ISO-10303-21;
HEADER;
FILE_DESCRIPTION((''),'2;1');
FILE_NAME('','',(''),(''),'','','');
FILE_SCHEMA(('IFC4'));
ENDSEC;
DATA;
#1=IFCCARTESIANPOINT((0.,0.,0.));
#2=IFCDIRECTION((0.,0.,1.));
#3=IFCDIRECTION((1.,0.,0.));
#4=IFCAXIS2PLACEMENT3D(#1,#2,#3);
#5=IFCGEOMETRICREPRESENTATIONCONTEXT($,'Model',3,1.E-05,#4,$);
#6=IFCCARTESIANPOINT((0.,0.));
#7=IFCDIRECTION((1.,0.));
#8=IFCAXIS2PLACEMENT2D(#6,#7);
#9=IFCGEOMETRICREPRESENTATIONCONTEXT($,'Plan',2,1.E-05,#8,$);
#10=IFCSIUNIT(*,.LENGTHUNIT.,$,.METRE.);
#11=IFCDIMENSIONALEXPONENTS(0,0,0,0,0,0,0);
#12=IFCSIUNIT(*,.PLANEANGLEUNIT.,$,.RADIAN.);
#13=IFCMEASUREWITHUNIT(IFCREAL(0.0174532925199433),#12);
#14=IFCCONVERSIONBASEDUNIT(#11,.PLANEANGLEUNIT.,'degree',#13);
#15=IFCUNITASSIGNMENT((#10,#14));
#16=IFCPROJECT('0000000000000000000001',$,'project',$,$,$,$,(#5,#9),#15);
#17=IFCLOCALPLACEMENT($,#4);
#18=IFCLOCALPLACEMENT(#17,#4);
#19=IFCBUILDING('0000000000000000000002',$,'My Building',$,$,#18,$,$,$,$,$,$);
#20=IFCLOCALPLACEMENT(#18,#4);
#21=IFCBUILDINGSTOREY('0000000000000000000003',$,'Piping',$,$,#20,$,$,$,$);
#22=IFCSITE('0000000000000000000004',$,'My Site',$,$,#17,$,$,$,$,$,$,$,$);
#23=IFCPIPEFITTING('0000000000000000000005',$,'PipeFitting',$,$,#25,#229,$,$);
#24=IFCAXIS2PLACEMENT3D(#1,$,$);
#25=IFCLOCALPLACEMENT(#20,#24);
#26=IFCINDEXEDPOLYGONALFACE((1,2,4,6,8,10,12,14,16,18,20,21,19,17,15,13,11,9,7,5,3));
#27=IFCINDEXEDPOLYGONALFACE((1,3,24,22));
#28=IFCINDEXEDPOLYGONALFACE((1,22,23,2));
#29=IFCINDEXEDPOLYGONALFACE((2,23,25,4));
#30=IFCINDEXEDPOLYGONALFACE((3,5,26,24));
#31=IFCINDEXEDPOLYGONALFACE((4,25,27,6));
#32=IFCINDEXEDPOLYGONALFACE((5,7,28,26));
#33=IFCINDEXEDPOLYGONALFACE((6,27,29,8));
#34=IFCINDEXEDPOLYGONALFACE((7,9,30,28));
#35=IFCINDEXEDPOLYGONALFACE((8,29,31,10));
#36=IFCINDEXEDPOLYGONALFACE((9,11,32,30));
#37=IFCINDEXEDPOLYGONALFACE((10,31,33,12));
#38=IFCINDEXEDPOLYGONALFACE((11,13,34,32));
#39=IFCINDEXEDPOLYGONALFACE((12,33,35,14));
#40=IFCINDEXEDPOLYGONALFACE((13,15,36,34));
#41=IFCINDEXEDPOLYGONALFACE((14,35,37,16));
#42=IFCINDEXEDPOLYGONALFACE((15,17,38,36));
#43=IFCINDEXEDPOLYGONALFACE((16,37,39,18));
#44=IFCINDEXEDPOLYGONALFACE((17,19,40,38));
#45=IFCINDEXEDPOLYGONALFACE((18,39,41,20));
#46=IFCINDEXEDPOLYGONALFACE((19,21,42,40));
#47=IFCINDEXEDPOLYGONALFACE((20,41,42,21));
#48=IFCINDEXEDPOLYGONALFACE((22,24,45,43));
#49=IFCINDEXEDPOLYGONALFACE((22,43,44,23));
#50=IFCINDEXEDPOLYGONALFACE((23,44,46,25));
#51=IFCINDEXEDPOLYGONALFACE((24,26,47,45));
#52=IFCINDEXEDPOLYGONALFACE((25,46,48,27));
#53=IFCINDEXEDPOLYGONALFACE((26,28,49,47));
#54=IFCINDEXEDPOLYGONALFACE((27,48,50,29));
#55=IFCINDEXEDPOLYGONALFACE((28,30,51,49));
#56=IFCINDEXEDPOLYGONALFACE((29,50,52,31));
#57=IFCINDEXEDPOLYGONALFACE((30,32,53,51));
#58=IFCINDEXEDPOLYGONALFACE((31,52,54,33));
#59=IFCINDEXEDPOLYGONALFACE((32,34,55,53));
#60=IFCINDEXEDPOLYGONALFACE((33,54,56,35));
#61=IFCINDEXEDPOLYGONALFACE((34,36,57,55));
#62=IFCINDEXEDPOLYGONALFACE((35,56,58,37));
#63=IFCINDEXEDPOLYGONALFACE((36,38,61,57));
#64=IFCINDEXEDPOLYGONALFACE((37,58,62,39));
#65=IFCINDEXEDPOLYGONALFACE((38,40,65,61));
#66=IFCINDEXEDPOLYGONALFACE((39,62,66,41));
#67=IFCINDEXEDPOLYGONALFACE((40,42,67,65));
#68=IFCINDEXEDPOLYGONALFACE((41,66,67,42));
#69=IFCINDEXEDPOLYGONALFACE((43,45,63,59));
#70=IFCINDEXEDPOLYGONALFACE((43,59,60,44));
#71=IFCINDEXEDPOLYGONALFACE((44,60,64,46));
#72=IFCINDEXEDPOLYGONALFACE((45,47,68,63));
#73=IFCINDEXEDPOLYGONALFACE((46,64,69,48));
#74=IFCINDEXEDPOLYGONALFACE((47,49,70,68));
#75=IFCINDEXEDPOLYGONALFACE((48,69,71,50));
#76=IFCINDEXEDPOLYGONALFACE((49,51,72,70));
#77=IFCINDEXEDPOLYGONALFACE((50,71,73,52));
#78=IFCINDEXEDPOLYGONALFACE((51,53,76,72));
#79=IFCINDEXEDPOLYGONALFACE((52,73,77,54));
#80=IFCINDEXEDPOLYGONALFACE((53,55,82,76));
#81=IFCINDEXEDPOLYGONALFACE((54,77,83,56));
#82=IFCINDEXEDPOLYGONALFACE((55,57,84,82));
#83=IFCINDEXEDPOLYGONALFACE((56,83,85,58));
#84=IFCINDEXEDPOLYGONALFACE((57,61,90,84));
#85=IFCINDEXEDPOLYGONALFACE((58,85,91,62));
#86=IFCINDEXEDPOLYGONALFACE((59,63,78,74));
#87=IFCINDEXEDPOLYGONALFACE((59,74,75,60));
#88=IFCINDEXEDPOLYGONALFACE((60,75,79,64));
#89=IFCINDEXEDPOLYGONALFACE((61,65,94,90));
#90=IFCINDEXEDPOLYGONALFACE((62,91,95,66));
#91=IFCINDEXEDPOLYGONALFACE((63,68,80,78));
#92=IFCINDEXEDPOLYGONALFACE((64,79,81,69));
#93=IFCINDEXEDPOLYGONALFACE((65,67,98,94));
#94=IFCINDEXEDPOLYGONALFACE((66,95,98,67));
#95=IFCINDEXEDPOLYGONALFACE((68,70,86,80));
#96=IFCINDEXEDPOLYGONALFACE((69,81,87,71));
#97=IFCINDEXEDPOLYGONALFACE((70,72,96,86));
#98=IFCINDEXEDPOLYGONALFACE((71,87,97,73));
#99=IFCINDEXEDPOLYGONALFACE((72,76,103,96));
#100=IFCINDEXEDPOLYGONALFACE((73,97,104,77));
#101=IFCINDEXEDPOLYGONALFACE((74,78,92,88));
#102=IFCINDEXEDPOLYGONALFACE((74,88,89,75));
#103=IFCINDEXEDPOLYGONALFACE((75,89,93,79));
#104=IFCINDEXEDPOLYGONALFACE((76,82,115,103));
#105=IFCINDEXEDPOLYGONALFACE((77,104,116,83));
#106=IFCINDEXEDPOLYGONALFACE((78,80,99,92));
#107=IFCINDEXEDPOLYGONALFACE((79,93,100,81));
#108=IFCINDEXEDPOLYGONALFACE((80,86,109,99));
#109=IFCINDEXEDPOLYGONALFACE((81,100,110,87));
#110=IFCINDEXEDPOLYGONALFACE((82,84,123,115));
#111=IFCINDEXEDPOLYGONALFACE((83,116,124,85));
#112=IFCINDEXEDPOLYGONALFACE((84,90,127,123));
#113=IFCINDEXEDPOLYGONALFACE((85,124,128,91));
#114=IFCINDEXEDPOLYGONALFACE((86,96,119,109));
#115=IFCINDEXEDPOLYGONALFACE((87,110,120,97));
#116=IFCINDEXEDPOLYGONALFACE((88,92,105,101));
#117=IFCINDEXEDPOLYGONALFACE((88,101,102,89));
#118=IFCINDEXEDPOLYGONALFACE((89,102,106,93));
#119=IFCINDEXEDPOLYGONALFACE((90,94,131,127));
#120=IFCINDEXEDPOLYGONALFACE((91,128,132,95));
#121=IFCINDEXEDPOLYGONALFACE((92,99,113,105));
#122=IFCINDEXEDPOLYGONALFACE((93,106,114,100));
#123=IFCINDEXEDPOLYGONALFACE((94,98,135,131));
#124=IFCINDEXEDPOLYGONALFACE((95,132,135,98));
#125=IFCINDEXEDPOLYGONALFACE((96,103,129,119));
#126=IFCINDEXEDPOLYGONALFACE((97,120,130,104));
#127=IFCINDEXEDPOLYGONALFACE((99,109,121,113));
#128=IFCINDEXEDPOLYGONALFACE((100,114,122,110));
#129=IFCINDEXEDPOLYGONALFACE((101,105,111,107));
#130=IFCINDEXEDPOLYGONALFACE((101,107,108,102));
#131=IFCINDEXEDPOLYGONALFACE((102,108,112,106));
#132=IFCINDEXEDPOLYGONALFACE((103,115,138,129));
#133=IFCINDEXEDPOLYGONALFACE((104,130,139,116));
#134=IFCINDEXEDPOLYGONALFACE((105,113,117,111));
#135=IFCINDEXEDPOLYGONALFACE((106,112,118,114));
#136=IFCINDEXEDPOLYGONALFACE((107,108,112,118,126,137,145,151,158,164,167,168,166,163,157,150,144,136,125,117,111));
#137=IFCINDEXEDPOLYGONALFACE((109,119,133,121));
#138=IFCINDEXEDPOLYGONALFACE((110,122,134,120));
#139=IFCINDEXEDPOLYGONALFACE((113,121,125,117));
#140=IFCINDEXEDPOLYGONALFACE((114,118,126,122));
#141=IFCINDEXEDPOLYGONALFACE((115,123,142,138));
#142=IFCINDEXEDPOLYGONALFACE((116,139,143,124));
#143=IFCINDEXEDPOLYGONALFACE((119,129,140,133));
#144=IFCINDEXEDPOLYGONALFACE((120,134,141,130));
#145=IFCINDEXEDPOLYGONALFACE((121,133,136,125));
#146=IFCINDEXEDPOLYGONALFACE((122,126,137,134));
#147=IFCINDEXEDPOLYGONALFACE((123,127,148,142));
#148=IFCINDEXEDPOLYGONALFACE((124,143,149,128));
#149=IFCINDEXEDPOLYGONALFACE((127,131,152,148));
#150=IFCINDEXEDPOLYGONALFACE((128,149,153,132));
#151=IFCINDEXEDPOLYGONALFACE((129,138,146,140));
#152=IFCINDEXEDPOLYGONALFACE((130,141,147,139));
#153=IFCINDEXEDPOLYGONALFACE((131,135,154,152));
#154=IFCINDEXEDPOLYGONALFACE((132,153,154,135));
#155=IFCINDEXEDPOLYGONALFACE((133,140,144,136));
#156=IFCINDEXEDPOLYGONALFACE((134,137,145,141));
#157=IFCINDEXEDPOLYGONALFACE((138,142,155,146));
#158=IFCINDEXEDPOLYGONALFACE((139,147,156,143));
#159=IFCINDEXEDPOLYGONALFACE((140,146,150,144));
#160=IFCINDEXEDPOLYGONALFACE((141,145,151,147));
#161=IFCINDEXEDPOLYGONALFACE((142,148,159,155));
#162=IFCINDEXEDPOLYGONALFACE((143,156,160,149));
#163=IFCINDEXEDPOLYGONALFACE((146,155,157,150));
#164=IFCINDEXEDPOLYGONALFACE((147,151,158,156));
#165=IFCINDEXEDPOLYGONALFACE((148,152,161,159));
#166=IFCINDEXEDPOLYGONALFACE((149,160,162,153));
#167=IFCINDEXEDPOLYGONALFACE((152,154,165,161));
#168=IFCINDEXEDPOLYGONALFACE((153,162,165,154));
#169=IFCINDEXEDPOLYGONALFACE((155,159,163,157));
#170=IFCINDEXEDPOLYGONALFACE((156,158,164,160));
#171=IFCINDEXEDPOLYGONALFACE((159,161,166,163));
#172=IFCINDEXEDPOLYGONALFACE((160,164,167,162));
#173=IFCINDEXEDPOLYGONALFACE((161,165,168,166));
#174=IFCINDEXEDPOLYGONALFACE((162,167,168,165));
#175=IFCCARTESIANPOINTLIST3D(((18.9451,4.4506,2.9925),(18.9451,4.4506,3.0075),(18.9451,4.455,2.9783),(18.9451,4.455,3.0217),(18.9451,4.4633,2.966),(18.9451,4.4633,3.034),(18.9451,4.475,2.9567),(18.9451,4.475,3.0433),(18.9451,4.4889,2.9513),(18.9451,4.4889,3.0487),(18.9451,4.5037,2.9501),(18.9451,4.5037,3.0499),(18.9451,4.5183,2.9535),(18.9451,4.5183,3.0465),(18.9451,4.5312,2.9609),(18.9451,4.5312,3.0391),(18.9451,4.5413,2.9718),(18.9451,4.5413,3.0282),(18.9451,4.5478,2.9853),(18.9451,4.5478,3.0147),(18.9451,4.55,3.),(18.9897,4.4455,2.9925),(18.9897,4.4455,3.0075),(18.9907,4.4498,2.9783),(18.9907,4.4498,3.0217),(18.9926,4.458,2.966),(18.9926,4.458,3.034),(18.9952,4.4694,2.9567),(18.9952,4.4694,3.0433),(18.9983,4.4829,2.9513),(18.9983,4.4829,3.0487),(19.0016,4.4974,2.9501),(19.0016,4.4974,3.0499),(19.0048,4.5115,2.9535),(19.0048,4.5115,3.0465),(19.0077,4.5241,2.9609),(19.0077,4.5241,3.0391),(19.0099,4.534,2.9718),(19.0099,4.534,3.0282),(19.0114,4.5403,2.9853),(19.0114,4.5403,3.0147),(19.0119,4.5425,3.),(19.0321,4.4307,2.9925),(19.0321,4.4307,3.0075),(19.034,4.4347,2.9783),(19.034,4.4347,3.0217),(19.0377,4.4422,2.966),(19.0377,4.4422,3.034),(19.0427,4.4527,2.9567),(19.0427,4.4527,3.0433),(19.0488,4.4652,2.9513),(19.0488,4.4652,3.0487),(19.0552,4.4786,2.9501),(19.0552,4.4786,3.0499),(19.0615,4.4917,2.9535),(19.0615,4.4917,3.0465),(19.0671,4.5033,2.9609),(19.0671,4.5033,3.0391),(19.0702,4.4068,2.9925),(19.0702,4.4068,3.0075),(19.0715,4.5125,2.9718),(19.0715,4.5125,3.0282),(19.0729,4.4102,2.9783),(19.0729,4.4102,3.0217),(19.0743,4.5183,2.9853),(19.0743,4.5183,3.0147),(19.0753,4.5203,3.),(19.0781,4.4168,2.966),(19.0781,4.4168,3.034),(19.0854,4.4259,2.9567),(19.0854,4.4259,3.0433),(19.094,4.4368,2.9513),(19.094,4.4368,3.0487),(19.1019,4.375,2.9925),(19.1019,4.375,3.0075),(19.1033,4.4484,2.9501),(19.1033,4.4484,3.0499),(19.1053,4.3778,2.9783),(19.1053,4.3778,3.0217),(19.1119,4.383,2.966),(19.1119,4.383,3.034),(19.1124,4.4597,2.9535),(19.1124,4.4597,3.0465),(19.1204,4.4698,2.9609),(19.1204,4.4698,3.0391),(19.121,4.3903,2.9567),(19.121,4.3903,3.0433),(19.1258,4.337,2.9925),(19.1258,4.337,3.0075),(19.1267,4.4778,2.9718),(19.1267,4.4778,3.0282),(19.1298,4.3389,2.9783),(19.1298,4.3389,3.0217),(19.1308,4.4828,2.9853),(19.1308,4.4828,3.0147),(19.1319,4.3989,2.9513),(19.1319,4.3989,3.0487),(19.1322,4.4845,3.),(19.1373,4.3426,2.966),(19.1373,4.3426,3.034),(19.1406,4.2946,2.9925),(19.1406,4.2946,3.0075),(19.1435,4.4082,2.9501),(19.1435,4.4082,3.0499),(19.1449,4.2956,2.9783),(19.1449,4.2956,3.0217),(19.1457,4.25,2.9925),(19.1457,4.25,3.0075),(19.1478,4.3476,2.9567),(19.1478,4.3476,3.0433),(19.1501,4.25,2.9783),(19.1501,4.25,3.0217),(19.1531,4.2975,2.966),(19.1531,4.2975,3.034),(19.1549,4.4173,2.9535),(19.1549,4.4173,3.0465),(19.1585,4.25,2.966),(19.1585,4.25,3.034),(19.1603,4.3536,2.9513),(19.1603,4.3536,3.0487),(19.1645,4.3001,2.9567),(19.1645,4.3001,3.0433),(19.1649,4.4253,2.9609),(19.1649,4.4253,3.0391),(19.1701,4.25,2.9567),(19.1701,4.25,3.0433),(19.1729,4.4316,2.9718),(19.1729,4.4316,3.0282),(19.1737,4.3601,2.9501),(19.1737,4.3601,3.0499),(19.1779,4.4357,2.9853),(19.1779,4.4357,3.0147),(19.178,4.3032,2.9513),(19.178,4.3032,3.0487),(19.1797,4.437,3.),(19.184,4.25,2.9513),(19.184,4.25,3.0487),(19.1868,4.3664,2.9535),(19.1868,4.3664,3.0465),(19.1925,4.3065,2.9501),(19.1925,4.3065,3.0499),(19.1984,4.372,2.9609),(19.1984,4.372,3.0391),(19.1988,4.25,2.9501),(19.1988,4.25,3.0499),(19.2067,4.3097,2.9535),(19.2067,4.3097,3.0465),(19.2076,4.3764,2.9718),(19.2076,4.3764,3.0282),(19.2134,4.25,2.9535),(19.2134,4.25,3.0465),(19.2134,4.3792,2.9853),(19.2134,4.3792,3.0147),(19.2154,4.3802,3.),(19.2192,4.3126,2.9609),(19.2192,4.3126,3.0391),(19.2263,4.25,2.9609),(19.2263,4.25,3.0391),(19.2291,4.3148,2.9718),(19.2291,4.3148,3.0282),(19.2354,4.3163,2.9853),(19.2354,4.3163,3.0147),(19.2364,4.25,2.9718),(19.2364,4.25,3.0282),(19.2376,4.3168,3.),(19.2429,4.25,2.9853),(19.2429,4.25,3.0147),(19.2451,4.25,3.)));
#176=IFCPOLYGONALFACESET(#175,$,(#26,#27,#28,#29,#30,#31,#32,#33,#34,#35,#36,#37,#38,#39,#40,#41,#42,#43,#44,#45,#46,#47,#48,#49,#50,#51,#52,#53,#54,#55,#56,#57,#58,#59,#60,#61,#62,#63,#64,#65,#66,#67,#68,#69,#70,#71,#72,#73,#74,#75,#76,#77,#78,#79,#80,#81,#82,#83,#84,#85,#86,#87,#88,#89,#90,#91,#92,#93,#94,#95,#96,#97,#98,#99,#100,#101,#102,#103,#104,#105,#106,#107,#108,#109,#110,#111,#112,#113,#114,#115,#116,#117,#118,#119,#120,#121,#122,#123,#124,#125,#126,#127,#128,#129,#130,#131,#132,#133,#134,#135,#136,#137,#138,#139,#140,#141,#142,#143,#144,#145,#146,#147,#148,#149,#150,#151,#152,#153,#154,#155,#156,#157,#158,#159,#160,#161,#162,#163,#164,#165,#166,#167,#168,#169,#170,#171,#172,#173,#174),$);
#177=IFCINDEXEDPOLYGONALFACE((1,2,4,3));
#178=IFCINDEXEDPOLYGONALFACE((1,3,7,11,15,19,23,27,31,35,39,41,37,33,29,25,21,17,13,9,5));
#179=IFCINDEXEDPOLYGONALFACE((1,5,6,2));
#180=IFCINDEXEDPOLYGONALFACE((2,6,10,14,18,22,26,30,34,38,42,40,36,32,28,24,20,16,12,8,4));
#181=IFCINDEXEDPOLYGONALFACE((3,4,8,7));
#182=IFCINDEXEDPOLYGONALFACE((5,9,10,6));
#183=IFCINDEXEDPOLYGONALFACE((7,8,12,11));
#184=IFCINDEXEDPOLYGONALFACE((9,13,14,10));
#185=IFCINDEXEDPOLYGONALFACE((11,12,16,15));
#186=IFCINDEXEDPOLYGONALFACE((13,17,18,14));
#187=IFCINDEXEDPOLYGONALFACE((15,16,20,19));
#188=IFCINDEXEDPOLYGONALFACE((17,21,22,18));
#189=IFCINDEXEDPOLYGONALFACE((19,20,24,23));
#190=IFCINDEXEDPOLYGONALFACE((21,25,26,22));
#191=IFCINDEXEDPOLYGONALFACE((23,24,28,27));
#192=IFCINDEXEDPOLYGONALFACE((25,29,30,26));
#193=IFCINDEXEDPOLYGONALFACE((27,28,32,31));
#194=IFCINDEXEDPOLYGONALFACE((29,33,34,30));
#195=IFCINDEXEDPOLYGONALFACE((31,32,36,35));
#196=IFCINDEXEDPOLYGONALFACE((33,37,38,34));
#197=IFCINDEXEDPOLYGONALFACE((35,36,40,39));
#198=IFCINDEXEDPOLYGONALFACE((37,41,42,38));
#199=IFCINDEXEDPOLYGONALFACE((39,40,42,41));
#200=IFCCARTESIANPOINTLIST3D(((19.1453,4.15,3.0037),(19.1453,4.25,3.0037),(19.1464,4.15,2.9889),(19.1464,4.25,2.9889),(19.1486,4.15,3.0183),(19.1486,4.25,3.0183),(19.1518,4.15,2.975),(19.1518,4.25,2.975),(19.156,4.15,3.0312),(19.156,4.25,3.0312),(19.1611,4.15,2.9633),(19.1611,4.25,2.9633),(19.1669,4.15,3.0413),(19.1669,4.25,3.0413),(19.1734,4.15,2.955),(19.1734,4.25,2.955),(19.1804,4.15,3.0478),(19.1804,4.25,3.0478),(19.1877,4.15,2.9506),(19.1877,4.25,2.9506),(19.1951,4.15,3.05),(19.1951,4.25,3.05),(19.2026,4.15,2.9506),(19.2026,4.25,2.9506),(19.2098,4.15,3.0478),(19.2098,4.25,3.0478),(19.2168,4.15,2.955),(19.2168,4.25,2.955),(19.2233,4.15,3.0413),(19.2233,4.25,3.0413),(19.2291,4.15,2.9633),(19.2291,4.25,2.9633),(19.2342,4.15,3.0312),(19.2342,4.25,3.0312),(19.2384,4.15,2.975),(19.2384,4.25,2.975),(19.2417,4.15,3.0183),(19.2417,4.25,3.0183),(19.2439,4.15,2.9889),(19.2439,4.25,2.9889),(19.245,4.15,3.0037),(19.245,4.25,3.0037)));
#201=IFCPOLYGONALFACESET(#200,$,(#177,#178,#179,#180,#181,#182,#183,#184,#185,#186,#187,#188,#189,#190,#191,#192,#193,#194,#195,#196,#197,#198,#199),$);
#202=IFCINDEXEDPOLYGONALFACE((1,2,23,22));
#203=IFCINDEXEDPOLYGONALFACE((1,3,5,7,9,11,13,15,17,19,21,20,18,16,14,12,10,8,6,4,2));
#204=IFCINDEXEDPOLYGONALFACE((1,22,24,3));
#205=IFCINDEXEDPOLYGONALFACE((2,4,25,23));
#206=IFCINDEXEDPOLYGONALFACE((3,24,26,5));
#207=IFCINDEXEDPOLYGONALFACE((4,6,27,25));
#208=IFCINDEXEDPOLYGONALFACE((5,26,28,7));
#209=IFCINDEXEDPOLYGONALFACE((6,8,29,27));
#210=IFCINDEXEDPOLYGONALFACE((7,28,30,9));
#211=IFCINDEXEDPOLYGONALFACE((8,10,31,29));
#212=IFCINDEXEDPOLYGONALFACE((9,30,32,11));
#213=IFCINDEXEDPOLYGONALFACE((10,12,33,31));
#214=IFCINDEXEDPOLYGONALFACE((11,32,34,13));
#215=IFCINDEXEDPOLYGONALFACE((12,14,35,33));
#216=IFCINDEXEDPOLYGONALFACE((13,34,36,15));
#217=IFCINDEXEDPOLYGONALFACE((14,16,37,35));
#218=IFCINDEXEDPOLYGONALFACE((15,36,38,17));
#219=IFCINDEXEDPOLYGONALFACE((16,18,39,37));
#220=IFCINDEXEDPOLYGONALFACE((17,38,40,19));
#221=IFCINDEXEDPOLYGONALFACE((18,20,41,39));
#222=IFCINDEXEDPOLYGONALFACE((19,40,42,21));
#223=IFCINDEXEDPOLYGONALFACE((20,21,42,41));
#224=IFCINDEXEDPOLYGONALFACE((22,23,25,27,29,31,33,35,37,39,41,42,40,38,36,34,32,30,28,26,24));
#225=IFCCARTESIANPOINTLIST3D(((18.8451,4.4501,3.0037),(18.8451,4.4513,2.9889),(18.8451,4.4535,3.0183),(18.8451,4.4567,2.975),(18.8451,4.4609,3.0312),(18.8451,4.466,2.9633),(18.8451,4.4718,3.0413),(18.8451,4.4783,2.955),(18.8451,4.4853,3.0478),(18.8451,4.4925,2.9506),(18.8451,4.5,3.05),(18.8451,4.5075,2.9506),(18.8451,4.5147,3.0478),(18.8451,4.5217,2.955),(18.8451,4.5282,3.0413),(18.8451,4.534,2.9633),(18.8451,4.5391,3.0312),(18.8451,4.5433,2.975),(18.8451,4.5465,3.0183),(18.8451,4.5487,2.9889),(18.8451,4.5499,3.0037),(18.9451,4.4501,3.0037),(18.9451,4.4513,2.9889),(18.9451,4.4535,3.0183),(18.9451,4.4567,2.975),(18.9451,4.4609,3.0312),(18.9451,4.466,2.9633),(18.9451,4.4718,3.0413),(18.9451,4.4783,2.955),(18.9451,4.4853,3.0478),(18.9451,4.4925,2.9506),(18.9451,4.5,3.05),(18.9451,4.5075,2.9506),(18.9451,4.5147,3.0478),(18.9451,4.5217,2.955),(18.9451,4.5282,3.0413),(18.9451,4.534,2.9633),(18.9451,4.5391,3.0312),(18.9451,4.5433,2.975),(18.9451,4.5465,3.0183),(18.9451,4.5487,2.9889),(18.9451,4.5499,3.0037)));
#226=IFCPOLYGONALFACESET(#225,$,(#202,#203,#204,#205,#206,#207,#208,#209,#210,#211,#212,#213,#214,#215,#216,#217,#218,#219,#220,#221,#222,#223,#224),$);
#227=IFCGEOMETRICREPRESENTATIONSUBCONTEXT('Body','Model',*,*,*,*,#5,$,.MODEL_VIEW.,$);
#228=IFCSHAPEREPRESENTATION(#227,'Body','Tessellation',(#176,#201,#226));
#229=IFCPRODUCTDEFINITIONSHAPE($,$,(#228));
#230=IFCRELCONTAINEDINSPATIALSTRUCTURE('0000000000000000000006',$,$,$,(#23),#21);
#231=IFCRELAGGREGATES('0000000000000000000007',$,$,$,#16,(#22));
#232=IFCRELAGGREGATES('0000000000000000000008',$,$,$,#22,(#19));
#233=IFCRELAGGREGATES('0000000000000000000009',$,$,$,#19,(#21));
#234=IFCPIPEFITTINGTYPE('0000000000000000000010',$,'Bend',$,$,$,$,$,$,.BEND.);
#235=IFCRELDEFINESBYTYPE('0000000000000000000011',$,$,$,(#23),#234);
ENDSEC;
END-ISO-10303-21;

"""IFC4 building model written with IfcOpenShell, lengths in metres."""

from ifc_helpers import new_model, entity, si_unit, converted_unit, frame, origin_with_axes, origin_2d_with_axis, place, context, subcontext, project, spatial, circle, extrude, source, transform, mapped, type_object, type_shapes, element, save


model = new_model("IFC4")

# Units and contexts
model_context = context("Model", 3, precision=1e-05, world=origin_with_axes())
plan_context = context("Plan", 2, precision=1e-05, world=origin_2d_with_axis())
body_context = subcontext(model_context, "Body", "Model", "MODEL_VIEW")
ifc_project = project(units=[si_unit("LENGTHUNIT", "METRE"), converted_unit("PLANEANGLEUNIT", "degree", entity("IfcReal", 0.0174532925199433), si_unit("PLANEANGLEUNIT", "RADIAN"), dimensions=[0, 0, 0, 0, 0, 0, 0])], contexts=[model_context, plan_context])

# Site, building, storey
site_placement = place(None, origin_with_axes())
site = spatial("IfcSite", under=ifc_project, at=site_placement, Name="My Site")
building_placement = place(site_placement, origin_with_axes())
building = spatial("IfcBuilding", under=site, at=building_placement, Name="My Building")
storey_placement = place(building_placement, origin_with_axes())
storey = spatial("IfcBuildingStorey", under=building, at=storey_placement, Name="Piping")

# Pipe fitting
pipe_fitting_type = type_object("IfcPipeFittingType", Name="Bend", PredefinedType="BEND")
shared_shape = source(origin_with_axes(), body_context, "Body", "SolidModel", [
    entity("IfcSweptDiskSolid", entity("IfcIndexedPolyCurve", entity("IfcCartesianPointList3D", [[0.0, 0.0, -0.1], [0.0, 0.0732, -0.2768], [0.0, 0.25, -0.35]]), [entity("IfcArcIndex", [1, 2, 3])]), 0.05),
    extrude(circle(Radius=0.05), origin_with_axes(), (0.0, 0.0, -1.0), 0.1),
    extrude(circle(Radius=0.05), frame((0.0, 0.25, -0.35), z_axis=(0.0, 1.0, 0.0), x_axis=(1.0, 0.0, 0.0)), (0.0, 0.0, 1.0), 0.1),
])
type_shapes(pipe_fitting_type, [shared_shape])
for number, where, z_axis, x_axis, name in (
    (1, (19.1951, 4.15, 3.0), (0.0, -1.0, 0.0), (0.0, 0.0, 1.0), "PipeFitting"),
):
    element("IfcPipeFitting", number, at=place(storey_placement, frame(where, z_axis=z_axis, x_axis=x_axis)), inside=storey, type_object=pipe_fitting_type, Name=name, context=body_context, shape_type="MappedRepresentation", body=[
        mapped(shared_shape, transform((0.0, 0.0, 0.0), x_axis=(1.0, 0.0, 0.0), y_axis=(0.0, 1.0, 0.0), z_axis=(0.0, 0.0, 1.0), scale=1.0)),
    ])

save(model, "model.ifc")
